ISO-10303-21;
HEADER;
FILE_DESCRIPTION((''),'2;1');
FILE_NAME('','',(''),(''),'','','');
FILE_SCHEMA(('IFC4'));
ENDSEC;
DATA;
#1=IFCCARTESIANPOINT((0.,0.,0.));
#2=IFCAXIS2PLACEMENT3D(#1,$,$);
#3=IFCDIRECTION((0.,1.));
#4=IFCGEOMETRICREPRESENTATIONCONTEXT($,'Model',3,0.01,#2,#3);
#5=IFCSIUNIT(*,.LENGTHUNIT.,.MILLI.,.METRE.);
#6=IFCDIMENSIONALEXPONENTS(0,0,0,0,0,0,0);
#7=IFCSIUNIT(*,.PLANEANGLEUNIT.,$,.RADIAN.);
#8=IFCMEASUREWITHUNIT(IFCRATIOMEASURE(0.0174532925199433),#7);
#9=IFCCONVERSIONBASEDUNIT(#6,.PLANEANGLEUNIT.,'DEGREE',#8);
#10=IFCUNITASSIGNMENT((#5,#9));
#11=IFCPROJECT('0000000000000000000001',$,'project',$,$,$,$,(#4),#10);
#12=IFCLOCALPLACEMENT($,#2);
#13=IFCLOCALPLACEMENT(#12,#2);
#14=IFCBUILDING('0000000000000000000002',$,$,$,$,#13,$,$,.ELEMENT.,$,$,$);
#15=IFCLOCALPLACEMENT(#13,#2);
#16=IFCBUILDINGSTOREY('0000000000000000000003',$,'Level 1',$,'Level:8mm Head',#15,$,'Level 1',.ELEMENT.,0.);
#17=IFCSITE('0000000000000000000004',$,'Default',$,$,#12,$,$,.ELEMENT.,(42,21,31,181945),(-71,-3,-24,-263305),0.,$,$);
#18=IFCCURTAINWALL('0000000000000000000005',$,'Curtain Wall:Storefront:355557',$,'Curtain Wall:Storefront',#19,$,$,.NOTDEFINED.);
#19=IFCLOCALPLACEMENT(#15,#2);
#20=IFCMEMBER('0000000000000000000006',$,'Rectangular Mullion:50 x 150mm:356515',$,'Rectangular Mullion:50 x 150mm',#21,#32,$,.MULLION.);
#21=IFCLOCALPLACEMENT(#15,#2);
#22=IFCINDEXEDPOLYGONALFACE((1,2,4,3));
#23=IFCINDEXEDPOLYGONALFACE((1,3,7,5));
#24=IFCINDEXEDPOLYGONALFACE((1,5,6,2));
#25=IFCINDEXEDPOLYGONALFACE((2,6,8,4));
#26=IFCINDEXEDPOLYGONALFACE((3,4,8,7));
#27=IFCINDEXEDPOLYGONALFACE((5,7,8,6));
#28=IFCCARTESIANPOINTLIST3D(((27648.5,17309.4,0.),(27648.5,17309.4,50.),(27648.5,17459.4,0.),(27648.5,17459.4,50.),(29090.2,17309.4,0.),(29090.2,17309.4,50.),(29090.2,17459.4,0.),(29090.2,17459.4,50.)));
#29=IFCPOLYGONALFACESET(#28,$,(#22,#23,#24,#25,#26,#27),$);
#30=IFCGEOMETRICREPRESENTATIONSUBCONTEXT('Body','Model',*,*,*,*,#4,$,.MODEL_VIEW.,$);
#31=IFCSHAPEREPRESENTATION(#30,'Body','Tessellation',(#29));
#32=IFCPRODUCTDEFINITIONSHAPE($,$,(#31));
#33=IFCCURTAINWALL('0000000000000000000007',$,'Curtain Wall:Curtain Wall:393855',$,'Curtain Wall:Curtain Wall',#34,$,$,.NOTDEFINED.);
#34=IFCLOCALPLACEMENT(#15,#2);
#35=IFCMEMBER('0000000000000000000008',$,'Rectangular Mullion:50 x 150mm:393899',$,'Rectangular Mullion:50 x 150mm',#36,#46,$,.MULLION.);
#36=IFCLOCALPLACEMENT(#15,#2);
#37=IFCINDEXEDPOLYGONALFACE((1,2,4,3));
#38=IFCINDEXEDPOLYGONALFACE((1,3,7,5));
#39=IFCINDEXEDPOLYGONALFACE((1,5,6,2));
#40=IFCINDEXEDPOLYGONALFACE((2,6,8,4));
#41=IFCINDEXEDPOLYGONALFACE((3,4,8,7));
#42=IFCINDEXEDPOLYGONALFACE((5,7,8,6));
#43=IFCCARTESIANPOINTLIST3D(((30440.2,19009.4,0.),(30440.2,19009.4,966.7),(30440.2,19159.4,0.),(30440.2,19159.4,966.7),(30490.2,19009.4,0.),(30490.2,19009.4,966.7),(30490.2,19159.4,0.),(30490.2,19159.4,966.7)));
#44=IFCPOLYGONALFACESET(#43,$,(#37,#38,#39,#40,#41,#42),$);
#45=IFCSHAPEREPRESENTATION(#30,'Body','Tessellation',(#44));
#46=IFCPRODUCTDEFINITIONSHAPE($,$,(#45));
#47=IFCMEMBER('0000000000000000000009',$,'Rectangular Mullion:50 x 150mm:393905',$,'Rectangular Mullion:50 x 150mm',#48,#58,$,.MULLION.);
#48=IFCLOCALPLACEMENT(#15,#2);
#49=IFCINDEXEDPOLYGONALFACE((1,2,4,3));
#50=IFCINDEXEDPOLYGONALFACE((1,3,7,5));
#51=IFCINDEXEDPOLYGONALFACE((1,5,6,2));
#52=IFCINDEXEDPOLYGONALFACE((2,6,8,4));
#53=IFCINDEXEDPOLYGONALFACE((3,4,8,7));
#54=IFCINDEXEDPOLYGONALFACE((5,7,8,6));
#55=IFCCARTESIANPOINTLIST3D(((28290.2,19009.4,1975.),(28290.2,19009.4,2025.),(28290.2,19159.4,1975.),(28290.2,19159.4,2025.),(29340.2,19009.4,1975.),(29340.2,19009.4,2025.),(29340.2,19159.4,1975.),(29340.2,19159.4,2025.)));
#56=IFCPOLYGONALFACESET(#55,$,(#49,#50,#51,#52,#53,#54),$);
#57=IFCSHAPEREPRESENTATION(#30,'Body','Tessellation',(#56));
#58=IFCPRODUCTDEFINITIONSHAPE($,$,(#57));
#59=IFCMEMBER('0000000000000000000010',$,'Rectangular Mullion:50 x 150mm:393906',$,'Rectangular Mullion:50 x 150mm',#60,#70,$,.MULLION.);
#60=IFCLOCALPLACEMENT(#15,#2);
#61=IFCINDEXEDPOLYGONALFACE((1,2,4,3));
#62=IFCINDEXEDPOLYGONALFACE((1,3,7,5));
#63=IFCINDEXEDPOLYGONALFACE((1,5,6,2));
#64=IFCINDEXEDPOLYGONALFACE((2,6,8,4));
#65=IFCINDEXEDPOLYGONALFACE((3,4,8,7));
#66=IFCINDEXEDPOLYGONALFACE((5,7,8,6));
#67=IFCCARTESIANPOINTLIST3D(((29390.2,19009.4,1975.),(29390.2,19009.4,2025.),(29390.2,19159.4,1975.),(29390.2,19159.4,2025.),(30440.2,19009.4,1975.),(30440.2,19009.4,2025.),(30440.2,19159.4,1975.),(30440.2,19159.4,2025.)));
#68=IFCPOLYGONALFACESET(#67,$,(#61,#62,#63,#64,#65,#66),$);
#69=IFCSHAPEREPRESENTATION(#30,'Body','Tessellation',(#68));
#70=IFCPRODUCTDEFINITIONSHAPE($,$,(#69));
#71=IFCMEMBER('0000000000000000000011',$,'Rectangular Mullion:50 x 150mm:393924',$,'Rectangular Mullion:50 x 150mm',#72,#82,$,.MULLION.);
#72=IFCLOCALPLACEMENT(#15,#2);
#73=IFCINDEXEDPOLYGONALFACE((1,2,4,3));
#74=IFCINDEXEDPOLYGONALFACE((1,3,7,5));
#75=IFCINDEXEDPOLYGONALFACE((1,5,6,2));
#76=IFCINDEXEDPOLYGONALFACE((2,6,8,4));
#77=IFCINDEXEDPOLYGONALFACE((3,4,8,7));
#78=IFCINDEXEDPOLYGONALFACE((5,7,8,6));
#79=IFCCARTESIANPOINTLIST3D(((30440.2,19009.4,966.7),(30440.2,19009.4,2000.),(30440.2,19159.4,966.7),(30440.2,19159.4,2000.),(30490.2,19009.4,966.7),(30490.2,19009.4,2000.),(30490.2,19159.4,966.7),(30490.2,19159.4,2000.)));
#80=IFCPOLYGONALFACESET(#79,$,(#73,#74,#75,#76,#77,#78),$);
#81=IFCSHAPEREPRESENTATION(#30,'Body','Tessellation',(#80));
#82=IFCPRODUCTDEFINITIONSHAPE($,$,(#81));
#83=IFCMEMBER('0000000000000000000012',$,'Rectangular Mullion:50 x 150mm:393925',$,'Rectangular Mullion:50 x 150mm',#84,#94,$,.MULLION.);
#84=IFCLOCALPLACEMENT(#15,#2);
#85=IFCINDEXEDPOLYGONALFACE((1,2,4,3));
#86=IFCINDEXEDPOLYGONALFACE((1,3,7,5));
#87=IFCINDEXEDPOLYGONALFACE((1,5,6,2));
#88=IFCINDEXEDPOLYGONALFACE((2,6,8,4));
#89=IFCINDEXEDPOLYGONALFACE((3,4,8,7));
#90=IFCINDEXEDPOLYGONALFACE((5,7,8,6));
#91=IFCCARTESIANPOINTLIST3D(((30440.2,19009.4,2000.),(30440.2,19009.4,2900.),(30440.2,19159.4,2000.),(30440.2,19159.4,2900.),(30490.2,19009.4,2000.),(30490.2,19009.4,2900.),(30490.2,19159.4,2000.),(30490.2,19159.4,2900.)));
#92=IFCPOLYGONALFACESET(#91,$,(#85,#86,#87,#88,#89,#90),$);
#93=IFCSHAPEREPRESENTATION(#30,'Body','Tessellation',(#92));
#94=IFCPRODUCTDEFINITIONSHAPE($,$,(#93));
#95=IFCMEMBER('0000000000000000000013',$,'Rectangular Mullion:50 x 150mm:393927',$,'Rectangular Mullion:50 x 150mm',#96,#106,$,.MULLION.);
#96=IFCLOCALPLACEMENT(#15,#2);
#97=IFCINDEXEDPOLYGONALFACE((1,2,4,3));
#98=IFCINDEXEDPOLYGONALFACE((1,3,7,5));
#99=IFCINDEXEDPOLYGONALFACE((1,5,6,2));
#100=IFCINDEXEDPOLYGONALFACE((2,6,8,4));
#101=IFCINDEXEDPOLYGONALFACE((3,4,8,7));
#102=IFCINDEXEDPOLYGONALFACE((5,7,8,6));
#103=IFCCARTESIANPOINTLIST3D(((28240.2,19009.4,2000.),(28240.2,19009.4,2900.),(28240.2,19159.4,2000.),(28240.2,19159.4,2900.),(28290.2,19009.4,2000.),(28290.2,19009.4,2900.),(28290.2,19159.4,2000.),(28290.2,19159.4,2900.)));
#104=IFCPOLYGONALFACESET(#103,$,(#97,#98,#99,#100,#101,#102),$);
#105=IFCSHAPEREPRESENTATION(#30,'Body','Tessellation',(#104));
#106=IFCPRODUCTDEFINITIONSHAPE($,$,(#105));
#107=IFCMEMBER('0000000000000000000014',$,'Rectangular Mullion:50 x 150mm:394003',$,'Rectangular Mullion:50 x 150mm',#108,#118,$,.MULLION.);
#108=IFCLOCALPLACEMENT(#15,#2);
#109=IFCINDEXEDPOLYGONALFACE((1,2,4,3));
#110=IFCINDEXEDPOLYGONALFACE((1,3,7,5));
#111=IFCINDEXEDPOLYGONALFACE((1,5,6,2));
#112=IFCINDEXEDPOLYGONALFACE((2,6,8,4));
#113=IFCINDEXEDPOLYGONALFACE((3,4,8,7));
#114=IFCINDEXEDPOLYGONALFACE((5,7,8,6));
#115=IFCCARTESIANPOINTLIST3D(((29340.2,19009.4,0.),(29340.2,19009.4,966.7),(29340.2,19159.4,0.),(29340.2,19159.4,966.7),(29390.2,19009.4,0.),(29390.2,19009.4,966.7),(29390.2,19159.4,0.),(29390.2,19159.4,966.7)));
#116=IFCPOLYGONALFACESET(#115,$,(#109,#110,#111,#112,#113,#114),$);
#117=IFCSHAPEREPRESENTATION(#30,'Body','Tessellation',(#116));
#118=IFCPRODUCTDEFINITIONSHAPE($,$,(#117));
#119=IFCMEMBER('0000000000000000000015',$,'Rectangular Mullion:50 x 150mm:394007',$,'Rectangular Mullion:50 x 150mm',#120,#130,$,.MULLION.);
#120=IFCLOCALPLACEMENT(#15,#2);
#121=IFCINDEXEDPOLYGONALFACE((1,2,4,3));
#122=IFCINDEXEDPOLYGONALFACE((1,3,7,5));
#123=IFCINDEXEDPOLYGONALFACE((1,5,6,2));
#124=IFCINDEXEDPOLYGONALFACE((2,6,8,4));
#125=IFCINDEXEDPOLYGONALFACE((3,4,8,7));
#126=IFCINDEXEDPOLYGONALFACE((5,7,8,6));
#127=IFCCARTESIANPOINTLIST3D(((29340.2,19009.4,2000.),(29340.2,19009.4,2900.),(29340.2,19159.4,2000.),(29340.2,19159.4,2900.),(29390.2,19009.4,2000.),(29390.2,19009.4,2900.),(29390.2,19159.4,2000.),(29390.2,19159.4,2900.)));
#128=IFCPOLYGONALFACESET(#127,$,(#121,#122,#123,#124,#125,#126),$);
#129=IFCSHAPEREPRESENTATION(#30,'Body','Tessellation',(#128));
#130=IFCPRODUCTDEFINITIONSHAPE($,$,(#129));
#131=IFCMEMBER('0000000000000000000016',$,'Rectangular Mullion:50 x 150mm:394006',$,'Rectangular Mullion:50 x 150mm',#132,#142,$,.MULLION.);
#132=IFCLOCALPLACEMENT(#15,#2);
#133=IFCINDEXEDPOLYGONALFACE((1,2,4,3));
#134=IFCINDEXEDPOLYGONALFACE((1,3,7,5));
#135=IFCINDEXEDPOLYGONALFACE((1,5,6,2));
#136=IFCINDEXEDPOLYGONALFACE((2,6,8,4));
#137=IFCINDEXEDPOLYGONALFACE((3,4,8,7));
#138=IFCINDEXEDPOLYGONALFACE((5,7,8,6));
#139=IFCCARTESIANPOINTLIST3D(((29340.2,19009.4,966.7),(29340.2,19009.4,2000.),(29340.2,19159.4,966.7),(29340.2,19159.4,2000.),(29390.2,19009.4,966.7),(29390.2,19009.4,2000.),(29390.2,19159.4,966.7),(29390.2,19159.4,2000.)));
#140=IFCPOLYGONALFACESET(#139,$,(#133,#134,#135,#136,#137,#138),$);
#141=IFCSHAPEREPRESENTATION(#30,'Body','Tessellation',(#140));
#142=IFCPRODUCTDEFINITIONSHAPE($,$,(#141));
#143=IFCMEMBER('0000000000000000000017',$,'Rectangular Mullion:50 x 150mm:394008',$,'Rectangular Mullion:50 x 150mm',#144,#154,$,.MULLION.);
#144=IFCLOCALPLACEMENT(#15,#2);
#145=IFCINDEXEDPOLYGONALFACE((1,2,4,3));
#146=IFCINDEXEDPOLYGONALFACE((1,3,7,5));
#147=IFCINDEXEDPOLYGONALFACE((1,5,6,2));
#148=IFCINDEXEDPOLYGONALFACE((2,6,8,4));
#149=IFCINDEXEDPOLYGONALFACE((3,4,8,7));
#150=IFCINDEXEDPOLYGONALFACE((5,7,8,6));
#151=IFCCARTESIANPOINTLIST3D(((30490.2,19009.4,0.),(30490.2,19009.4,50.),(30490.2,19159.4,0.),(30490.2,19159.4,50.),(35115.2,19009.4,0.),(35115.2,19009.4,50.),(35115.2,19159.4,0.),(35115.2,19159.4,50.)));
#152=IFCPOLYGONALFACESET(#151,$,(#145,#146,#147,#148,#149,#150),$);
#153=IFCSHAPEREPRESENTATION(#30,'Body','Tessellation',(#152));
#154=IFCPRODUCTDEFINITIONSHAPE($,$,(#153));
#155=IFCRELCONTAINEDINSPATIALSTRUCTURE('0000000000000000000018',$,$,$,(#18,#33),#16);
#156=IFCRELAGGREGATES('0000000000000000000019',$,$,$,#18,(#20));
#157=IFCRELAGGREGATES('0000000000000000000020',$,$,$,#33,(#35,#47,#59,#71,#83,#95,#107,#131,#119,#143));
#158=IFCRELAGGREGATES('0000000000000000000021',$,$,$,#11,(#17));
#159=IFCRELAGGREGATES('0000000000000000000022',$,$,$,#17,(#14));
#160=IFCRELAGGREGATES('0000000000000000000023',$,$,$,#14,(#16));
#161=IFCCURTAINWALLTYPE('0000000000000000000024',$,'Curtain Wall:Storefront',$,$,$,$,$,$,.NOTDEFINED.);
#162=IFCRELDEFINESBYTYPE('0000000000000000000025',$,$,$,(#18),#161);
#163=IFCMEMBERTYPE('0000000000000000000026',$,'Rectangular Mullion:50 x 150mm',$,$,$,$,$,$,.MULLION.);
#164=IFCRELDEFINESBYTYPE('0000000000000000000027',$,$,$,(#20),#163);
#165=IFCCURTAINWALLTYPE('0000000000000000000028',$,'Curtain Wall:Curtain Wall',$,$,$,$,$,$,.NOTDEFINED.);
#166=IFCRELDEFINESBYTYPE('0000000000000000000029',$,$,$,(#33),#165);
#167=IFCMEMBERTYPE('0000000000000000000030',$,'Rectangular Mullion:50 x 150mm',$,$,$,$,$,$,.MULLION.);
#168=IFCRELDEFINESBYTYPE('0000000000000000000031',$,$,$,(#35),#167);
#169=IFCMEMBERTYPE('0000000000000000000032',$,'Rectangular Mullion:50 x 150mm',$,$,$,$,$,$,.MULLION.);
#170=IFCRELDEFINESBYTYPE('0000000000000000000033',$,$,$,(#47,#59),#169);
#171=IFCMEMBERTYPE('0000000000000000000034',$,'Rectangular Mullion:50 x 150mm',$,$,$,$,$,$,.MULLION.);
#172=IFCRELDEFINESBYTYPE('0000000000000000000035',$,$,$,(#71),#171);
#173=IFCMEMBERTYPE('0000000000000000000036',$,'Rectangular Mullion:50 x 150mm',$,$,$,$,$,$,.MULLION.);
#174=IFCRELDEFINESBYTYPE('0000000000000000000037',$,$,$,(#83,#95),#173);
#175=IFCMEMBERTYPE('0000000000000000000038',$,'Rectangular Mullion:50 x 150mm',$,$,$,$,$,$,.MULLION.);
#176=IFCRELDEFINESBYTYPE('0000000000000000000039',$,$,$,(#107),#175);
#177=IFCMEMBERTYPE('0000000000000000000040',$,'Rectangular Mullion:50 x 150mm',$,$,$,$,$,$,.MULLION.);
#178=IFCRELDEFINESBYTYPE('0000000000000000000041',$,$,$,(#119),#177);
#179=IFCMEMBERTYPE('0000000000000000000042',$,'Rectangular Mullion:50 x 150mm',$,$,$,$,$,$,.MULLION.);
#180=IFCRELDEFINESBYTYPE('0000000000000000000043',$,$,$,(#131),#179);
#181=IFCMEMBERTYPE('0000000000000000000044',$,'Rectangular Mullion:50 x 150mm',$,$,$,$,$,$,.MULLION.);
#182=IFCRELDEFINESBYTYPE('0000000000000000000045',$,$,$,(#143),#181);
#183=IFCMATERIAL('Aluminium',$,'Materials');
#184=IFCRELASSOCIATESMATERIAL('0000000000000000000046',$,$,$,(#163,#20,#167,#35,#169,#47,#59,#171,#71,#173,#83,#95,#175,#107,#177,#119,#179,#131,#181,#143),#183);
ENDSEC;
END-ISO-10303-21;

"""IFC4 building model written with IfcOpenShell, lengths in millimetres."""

from ifc_helpers import new_model, entity, si_unit, converted_unit, direction, frame, origin, place, context, subcontext, project, spatial, indexed_curve, outline, extrude, source, transform, mapped, material, type_object, type_shapes, element, aggregate, save


model = new_model("IFC4")

# Units and contexts
model_context = context("Model", 3, precision=0.01, world=origin(), true_north=direction((0.0, 1.0)))
body_context = subcontext(model_context, "Body", "Model", "MODEL_VIEW")
ifc_project = project(units=[si_unit("LENGTHUNIT", "METRE", prefix="MILLI"), converted_unit("PLANEANGLEUNIT", "DEGREE", entity("IfcRatioMeasure", 0.0174532925199433), si_unit("PLANEANGLEUNIT", "RADIAN"), dimensions=[0, 0, 0, 0, 0, 0, 0])], contexts=[model_context])

# Site, building, storey
site_placement = place(None, origin())
site = spatial("IfcSite", under=ifc_project, at=site_placement, Name="Default", CompositionType="ELEMENT", RefLatitude=(42, 21, 31, 181945), RefLongitude=(-71, -3, -24, -263305), RefElevation=0.0)
building_placement = place(site_placement, origin())
building = spatial("IfcBuilding", under=site, at=building_placement, CompositionType="ELEMENT")
storey_placement = place(building_placement, origin())
storey = spatial("IfcBuildingStorey", under=building, at=storey_placement, Name="Level 1", ObjectType="Level:8mm Head", LongName="Level 1", CompositionType="ELEMENT", Elevation=0.0)

# Shared definitions
curtain_wall_type_1 = type_object("IfcCurtainWallType", Name="Curtain Wall:Storefront", PredefinedType="NOTDEFINED")
ifc_material_1 = material(Name="Aluminium", Category="Materials")

# Curtain wall
curtain_wall_1_placement = place(storey_placement, origin())
curtain_wall_1 = element("IfcCurtainWall", 1, at=curtain_wall_1_placement, inside=storey, type_object=curtain_wall_type_1, Name="Curtain Wall:Storefront:355557", ObjectType="Curtain Wall:Storefront", PredefinedType="NOTDEFINED")

# Member
member_type_1 = type_object("IfcMemberType", Name="Rectangular Mullion:50 x 150mm", PredefinedType="MULLION", material=ifc_material_1)
shared_shape_1 = source(origin(), body_context, "Body", "SweptSolid", [
    extrude(outline(indexed_curve([(-75.0, -25.0), (75.0, -25.0), (75.0, 25.0), (-75.0, 25.0), (-75.0, -25.0)], self_intersect=False)), frame((-25.0, 0.0, -1441.7), z_axis=(0.0, 0.0, 1.0), x_axis=(0.0, -1.0, 0.0)), (0.0, 0.0, 1.0), 1441.7),
])
type_shapes(member_type_1, [shared_shape_1])
member_1_placement = place(storey_placement, frame((29090.2, 17384.4, 0.0), z_axis=(1.0, 0.0, 0.0), x_axis=(0.0, 0.0, -1.0)))
member_1 = element("IfcMember", 2, at=member_1_placement, type_object=member_type_1, material=ifc_material_1, Name="Rectangular Mullion:50 x 150mm:356515", ObjectType="Rectangular Mullion:50 x 150mm", PredefinedType="MULLION", context=body_context, shape_type="MappedRepresentation", body=[
    mapped(shared_shape_1, transform((0.0, 0.0, 0.0), scale=1.0)),
])

# Curtain wall, members
curtain_wall_type_2 = type_object("IfcCurtainWallType", Name="Curtain Wall:Curtain Wall", PredefinedType="NOTDEFINED")
curtain_wall_2_placement = place(storey_placement, origin())
curtain_wall_2 = element("IfcCurtainWall", 3, at=curtain_wall_2_placement, inside=storey, type_object=curtain_wall_type_2, Name="Curtain Wall:Curtain Wall:393855", ObjectType="Curtain Wall:Curtain Wall", PredefinedType="NOTDEFINED")
member_type_2 = type_object("IfcMemberType", Name="Rectangular Mullion:50 x 150mm", PredefinedType="MULLION", material=ifc_material_1)
shared_shape_2 = source(origin(), body_context, "Body", "SweptSolid", [
    extrude(outline(indexed_curve([(-75.0, -25.0), (75.0, -25.0), (75.0, 25.0), (-75.0, 25.0), (-75.0, -25.0)], self_intersect=False)), frame((0.0, 0.0, -966.7), z_axis=(0.0, 0.0, 1.0), x_axis=(0.0, -1.0, 0.0)), (0.0, 0.0, 1.0), 966.7),
])
type_shapes(member_type_2, [shared_shape_2])
member_2_placement = place(storey_placement, frame((30465.2, 19084.4, 0.0), z_axis=(0.0, 0.0, -1.0), x_axis=(1.0, 0.0, 0.0)))
member_2 = element("IfcMember", 4, at=member_2_placement, type_object=member_type_2, material=ifc_material_1, Name="Rectangular Mullion:50 x 150mm:393899", ObjectType="Rectangular Mullion:50 x 150mm", PredefinedType="MULLION", context=body_context, shape_type="MappedRepresentation", body=[
    mapped(shared_shape_2, transform((0.0, 0.0, 0.0), scale=1.0)),
])
member_type_3 = type_object("IfcMemberType", Name="Rectangular Mullion:50 x 150mm", PredefinedType="MULLION", material=ifc_material_1)
shared_shape_3 = source(origin(), body_context, "Body", "SweptSolid", [
    extrude(outline(indexed_curve([(-75.0, -25.0), (75.0, -25.0), (75.0, 25.0), (-75.0, 25.0), (-75.0, -25.0)], self_intersect=False)), frame((0.0, 0.0, -1050.0), z_axis=(0.0, 0.0, 1.0), x_axis=(0.0, -1.0, 0.0)), (0.0, 0.0, 1.0), 1050.0),
])
type_shapes(member_type_3, [shared_shape_3])
member_3_placement = place(storey_placement, frame((29340.2, 19084.4, 2000.0), z_axis=(1.0, 0.0, 0.0), x_axis=(0.0, 0.0, 1.0)))
member_3 = element("IfcMember", 5, at=member_3_placement, type_object=member_type_3, material=ifc_material_1, Name="Rectangular Mullion:50 x 150mm:393905", ObjectType="Rectangular Mullion:50 x 150mm", PredefinedType="MULLION", context=body_context, shape_type="MappedRepresentation", body=[
    mapped(shared_shape_3, transform((0.0, 0.0, 0.0), scale=1.0)),
])
member_4_placement = place(storey_placement, frame((30440.2, 19084.4, 2000.0), z_axis=(1.0, 0.0, 0.0), x_axis=(0.0, 0.0, 1.0)))
member_4 = element("IfcMember", 6, at=member_4_placement, type_object=member_type_3, material=ifc_material_1, Name="Rectangular Mullion:50 x 150mm:393906", ObjectType="Rectangular Mullion:50 x 150mm", PredefinedType="MULLION", context=body_context, shape_type="MappedRepresentation", body=[
    mapped(shared_shape_3, transform((0.0, 0.0, 0.0), scale=1.0)),
])
member_type_4 = type_object("IfcMemberType", Name="Rectangular Mullion:50 x 150mm", PredefinedType="MULLION", material=ifc_material_1)
shared_shape_4 = source(origin(), body_context, "Body", "SweptSolid", [
    extrude(outline(indexed_curve([(-75.0, -25.0), (75.0, -25.0), (75.0, 25.0), (-75.0, 25.0), (-75.0, -25.0)], self_intersect=False)), frame((0.0, 0.0, -1033.3), z_axis=(0.0, 0.0, 1.0), x_axis=(0.0, -1.0, 0.0)), (0.0, 0.0, 1.0), 1033.3),
])
type_shapes(member_type_4, [shared_shape_4])
member_5_placement = place(storey_placement, frame((30465.2, 19084.4, 966.7), z_axis=(0.0, 0.0, -1.0), x_axis=(1.0, 0.0, 0.0)))
member_5 = element("IfcMember", 7, at=member_5_placement, type_object=member_type_4, material=ifc_material_1, Name="Rectangular Mullion:50 x 150mm:393924", ObjectType="Rectangular Mullion:50 x 150mm", PredefinedType="MULLION", context=body_context, shape_type="MappedRepresentation", body=[
    mapped(shared_shape_4, transform((0.0, 0.0, 0.0), scale=1.0)),
])
member_type_5 = type_object("IfcMemberType", Name="Rectangular Mullion:50 x 150mm", PredefinedType="MULLION", material=ifc_material_1)
shared_shape_5 = source(origin(), body_context, "Body", "SweptSolid", [
    extrude(outline(indexed_curve([(-75.0, -25.0), (75.0, -25.0), (75.0, 25.0), (-75.0, 25.0), (-75.0, -25.0)], self_intersect=False)), frame((0.0, 0.0, -900.0), z_axis=(0.0, 0.0, 1.0), x_axis=(0.0, -1.0, 0.0)), (0.0, 0.0, 1.0), 900.0),
])
type_shapes(member_type_5, [shared_shape_5])
member_6_placement = place(storey_placement, frame((30465.2, 19084.4, 2000.0), z_axis=(0.0, 0.0, -1.0), x_axis=(1.0, 0.0, 0.0)))
member_6 = element("IfcMember", 8, at=member_6_placement, type_object=member_type_5, material=ifc_material_1, Name="Rectangular Mullion:50 x 150mm:393925", ObjectType="Rectangular Mullion:50 x 150mm", PredefinedType="MULLION", context=body_context, shape_type="MappedRepresentation", body=[
    mapped(shared_shape_5, transform((0.0, 0.0, 0.0), scale=1.0)),
])
member_7_placement = place(storey_placement, frame((28265.2, 19084.4, 2000.0), z_axis=(0.0, 0.0, -1.0), x_axis=(1.0, 0.0, 0.0)))
member_7 = element("IfcMember", 9, at=member_7_placement, type_object=member_type_5, material=ifc_material_1, Name="Rectangular Mullion:50 x 150mm:393927", ObjectType="Rectangular Mullion:50 x 150mm", PredefinedType="MULLION", context=body_context, shape_type="MappedRepresentation", body=[
    mapped(shared_shape_5, transform((0.0, 0.0, 0.0), scale=1.0)),
])
member_type_6 = type_object("IfcMemberType", Name="Rectangular Mullion:50 x 150mm", PredefinedType="MULLION", material=ifc_material_1)
shared_shape_6 = source(origin(), body_context, "Body", "SweptSolid", [
    extrude(outline(indexed_curve([(-75.0, -25.0), (75.0, -25.0), (75.0, 25.0), (-75.0, 25.0), (-75.0, -25.0)], self_intersect=False)), frame((0.0, 0.0, -966.7), z_axis=(0.0, 0.0, 1.0), x_axis=(0.0, -1.0, 0.0)), (0.0, 0.0, 1.0), 966.7),
])
type_shapes(member_type_6, [shared_shape_6])
member_8_placement = place(storey_placement, frame((29365.2, 19084.4, 0.0), z_axis=(0.0, 0.0, -1.0), x_axis=(1.0, 0.0, 0.0)))
member_8 = element("IfcMember", 10, at=member_8_placement, type_object=member_type_6, material=ifc_material_1, Name="Rectangular Mullion:50 x 150mm:394003", ObjectType="Rectangular Mullion:50 x 150mm", PredefinedType="MULLION", context=body_context, shape_type="MappedRepresentation", body=[
    mapped(shared_shape_6, transform((0.0, 0.0, 0.0), scale=1.0)),
])
member_type_7 = type_object("IfcMemberType", Name="Rectangular Mullion:50 x 150mm", PredefinedType="MULLION", material=ifc_material_1)
shared_shape_7 = source(origin(), body_context, "Body", "SweptSolid", [
    extrude(outline(indexed_curve([(-75.0, -25.0), (75.0, -25.0), (75.0, 25.0), (-75.0, 25.0), (-75.0, -25.0)], self_intersect=False)), frame((0.0, 0.0, -900.0), z_axis=(0.0, 0.0, 1.0), x_axis=(0.0, -1.0, 0.0)), (0.0, 0.0, 1.0), 900.0),
])
type_shapes(member_type_7, [shared_shape_7])
member_9_placement = place(storey_placement, frame((29365.2, 19084.4, 2000.0), z_axis=(0.0, 0.0, -1.0), x_axis=(1.0, 0.0, 0.0)))
member_9 = element("IfcMember", 11, at=member_9_placement, type_object=member_type_7, material=ifc_material_1, Name="Rectangular Mullion:50 x 150mm:394007", ObjectType="Rectangular Mullion:50 x 150mm", PredefinedType="MULLION", context=body_context, shape_type="MappedRepresentation", body=[
    mapped(shared_shape_7, transform((0.0, 0.0, 0.0), scale=1.0)),
])
member_type_8 = type_object("IfcMemberType", Name="Rectangular Mullion:50 x 150mm", PredefinedType="MULLION", material=ifc_material_1)
shared_shape_8 = source(origin(), body_context, "Body", "SweptSolid", [
    extrude(outline(indexed_curve([(-75.0, -25.0), (75.0, -25.0), (75.0, 25.0), (-75.0, 25.0), (-75.0, -25.0)], self_intersect=False)), frame((0.0, 0.0, -1033.3), z_axis=(0.0, 0.0, 1.0), x_axis=(0.0, -1.0, 0.0)), (0.0, 0.0, 1.0), 1033.3),
])
type_shapes(member_type_8, [shared_shape_8])
member_10_placement = place(storey_placement, frame((29365.2, 19084.4, 966.7), z_axis=(0.0, 0.0, -1.0), x_axis=(1.0, 0.0, 0.0)))
member_10 = element("IfcMember", 12, at=member_10_placement, type_object=member_type_8, material=ifc_material_1, Name="Rectangular Mullion:50 x 150mm:394006", ObjectType="Rectangular Mullion:50 x 150mm", PredefinedType="MULLION", context=body_context, shape_type="MappedRepresentation", body=[
    mapped(shared_shape_8, transform((0.0, 0.0, 0.0), scale=1.0)),
])
member_type_9 = type_object("IfcMemberType", Name="Rectangular Mullion:50 x 150mm", PredefinedType="MULLION", material=ifc_material_1)
shared_shape_9 = source(origin(), body_context, "Body", "SweptSolid", [
    extrude(outline(indexed_curve([(-75.0, -25.0), (75.0, -25.0), (75.0, 25.0), (-75.0, 25.0), (-75.0, -25.0)], self_intersect=False)), frame((-25.0, 0.0, -4625.0), z_axis=(0.0, 0.0, 1.0), x_axis=(0.0, -1.0, 0.0)), (0.0, 0.0, 1.0), 4625.0),
])
type_shapes(member_type_9, [shared_shape_9])
member_11_placement = place(storey_placement, frame((30490.2, 19084.4, 0.0), z_axis=(-1.0, 0.0, 0.0), x_axis=(0.0, 0.0, -1.0)))
member_11 = element("IfcMember", 13, at=member_11_placement, type_object=member_type_9, material=ifc_material_1, Name="Rectangular Mullion:50 x 150mm:394008", ObjectType="Rectangular Mullion:50 x 150mm", PredefinedType="MULLION", context=body_context, shape_type="MappedRepresentation", body=[
    mapped(shared_shape_9, transform((0.0, 0.0, 0.0), scale=1.0)),
])

aggregate(curtain_wall_1, [member_1])

aggregate(curtain_wall_2, [member_2, member_3, member_4, member_5, member_6, member_7, member_8, member_10, member_9, member_11])

save(model, "model.ifc")
